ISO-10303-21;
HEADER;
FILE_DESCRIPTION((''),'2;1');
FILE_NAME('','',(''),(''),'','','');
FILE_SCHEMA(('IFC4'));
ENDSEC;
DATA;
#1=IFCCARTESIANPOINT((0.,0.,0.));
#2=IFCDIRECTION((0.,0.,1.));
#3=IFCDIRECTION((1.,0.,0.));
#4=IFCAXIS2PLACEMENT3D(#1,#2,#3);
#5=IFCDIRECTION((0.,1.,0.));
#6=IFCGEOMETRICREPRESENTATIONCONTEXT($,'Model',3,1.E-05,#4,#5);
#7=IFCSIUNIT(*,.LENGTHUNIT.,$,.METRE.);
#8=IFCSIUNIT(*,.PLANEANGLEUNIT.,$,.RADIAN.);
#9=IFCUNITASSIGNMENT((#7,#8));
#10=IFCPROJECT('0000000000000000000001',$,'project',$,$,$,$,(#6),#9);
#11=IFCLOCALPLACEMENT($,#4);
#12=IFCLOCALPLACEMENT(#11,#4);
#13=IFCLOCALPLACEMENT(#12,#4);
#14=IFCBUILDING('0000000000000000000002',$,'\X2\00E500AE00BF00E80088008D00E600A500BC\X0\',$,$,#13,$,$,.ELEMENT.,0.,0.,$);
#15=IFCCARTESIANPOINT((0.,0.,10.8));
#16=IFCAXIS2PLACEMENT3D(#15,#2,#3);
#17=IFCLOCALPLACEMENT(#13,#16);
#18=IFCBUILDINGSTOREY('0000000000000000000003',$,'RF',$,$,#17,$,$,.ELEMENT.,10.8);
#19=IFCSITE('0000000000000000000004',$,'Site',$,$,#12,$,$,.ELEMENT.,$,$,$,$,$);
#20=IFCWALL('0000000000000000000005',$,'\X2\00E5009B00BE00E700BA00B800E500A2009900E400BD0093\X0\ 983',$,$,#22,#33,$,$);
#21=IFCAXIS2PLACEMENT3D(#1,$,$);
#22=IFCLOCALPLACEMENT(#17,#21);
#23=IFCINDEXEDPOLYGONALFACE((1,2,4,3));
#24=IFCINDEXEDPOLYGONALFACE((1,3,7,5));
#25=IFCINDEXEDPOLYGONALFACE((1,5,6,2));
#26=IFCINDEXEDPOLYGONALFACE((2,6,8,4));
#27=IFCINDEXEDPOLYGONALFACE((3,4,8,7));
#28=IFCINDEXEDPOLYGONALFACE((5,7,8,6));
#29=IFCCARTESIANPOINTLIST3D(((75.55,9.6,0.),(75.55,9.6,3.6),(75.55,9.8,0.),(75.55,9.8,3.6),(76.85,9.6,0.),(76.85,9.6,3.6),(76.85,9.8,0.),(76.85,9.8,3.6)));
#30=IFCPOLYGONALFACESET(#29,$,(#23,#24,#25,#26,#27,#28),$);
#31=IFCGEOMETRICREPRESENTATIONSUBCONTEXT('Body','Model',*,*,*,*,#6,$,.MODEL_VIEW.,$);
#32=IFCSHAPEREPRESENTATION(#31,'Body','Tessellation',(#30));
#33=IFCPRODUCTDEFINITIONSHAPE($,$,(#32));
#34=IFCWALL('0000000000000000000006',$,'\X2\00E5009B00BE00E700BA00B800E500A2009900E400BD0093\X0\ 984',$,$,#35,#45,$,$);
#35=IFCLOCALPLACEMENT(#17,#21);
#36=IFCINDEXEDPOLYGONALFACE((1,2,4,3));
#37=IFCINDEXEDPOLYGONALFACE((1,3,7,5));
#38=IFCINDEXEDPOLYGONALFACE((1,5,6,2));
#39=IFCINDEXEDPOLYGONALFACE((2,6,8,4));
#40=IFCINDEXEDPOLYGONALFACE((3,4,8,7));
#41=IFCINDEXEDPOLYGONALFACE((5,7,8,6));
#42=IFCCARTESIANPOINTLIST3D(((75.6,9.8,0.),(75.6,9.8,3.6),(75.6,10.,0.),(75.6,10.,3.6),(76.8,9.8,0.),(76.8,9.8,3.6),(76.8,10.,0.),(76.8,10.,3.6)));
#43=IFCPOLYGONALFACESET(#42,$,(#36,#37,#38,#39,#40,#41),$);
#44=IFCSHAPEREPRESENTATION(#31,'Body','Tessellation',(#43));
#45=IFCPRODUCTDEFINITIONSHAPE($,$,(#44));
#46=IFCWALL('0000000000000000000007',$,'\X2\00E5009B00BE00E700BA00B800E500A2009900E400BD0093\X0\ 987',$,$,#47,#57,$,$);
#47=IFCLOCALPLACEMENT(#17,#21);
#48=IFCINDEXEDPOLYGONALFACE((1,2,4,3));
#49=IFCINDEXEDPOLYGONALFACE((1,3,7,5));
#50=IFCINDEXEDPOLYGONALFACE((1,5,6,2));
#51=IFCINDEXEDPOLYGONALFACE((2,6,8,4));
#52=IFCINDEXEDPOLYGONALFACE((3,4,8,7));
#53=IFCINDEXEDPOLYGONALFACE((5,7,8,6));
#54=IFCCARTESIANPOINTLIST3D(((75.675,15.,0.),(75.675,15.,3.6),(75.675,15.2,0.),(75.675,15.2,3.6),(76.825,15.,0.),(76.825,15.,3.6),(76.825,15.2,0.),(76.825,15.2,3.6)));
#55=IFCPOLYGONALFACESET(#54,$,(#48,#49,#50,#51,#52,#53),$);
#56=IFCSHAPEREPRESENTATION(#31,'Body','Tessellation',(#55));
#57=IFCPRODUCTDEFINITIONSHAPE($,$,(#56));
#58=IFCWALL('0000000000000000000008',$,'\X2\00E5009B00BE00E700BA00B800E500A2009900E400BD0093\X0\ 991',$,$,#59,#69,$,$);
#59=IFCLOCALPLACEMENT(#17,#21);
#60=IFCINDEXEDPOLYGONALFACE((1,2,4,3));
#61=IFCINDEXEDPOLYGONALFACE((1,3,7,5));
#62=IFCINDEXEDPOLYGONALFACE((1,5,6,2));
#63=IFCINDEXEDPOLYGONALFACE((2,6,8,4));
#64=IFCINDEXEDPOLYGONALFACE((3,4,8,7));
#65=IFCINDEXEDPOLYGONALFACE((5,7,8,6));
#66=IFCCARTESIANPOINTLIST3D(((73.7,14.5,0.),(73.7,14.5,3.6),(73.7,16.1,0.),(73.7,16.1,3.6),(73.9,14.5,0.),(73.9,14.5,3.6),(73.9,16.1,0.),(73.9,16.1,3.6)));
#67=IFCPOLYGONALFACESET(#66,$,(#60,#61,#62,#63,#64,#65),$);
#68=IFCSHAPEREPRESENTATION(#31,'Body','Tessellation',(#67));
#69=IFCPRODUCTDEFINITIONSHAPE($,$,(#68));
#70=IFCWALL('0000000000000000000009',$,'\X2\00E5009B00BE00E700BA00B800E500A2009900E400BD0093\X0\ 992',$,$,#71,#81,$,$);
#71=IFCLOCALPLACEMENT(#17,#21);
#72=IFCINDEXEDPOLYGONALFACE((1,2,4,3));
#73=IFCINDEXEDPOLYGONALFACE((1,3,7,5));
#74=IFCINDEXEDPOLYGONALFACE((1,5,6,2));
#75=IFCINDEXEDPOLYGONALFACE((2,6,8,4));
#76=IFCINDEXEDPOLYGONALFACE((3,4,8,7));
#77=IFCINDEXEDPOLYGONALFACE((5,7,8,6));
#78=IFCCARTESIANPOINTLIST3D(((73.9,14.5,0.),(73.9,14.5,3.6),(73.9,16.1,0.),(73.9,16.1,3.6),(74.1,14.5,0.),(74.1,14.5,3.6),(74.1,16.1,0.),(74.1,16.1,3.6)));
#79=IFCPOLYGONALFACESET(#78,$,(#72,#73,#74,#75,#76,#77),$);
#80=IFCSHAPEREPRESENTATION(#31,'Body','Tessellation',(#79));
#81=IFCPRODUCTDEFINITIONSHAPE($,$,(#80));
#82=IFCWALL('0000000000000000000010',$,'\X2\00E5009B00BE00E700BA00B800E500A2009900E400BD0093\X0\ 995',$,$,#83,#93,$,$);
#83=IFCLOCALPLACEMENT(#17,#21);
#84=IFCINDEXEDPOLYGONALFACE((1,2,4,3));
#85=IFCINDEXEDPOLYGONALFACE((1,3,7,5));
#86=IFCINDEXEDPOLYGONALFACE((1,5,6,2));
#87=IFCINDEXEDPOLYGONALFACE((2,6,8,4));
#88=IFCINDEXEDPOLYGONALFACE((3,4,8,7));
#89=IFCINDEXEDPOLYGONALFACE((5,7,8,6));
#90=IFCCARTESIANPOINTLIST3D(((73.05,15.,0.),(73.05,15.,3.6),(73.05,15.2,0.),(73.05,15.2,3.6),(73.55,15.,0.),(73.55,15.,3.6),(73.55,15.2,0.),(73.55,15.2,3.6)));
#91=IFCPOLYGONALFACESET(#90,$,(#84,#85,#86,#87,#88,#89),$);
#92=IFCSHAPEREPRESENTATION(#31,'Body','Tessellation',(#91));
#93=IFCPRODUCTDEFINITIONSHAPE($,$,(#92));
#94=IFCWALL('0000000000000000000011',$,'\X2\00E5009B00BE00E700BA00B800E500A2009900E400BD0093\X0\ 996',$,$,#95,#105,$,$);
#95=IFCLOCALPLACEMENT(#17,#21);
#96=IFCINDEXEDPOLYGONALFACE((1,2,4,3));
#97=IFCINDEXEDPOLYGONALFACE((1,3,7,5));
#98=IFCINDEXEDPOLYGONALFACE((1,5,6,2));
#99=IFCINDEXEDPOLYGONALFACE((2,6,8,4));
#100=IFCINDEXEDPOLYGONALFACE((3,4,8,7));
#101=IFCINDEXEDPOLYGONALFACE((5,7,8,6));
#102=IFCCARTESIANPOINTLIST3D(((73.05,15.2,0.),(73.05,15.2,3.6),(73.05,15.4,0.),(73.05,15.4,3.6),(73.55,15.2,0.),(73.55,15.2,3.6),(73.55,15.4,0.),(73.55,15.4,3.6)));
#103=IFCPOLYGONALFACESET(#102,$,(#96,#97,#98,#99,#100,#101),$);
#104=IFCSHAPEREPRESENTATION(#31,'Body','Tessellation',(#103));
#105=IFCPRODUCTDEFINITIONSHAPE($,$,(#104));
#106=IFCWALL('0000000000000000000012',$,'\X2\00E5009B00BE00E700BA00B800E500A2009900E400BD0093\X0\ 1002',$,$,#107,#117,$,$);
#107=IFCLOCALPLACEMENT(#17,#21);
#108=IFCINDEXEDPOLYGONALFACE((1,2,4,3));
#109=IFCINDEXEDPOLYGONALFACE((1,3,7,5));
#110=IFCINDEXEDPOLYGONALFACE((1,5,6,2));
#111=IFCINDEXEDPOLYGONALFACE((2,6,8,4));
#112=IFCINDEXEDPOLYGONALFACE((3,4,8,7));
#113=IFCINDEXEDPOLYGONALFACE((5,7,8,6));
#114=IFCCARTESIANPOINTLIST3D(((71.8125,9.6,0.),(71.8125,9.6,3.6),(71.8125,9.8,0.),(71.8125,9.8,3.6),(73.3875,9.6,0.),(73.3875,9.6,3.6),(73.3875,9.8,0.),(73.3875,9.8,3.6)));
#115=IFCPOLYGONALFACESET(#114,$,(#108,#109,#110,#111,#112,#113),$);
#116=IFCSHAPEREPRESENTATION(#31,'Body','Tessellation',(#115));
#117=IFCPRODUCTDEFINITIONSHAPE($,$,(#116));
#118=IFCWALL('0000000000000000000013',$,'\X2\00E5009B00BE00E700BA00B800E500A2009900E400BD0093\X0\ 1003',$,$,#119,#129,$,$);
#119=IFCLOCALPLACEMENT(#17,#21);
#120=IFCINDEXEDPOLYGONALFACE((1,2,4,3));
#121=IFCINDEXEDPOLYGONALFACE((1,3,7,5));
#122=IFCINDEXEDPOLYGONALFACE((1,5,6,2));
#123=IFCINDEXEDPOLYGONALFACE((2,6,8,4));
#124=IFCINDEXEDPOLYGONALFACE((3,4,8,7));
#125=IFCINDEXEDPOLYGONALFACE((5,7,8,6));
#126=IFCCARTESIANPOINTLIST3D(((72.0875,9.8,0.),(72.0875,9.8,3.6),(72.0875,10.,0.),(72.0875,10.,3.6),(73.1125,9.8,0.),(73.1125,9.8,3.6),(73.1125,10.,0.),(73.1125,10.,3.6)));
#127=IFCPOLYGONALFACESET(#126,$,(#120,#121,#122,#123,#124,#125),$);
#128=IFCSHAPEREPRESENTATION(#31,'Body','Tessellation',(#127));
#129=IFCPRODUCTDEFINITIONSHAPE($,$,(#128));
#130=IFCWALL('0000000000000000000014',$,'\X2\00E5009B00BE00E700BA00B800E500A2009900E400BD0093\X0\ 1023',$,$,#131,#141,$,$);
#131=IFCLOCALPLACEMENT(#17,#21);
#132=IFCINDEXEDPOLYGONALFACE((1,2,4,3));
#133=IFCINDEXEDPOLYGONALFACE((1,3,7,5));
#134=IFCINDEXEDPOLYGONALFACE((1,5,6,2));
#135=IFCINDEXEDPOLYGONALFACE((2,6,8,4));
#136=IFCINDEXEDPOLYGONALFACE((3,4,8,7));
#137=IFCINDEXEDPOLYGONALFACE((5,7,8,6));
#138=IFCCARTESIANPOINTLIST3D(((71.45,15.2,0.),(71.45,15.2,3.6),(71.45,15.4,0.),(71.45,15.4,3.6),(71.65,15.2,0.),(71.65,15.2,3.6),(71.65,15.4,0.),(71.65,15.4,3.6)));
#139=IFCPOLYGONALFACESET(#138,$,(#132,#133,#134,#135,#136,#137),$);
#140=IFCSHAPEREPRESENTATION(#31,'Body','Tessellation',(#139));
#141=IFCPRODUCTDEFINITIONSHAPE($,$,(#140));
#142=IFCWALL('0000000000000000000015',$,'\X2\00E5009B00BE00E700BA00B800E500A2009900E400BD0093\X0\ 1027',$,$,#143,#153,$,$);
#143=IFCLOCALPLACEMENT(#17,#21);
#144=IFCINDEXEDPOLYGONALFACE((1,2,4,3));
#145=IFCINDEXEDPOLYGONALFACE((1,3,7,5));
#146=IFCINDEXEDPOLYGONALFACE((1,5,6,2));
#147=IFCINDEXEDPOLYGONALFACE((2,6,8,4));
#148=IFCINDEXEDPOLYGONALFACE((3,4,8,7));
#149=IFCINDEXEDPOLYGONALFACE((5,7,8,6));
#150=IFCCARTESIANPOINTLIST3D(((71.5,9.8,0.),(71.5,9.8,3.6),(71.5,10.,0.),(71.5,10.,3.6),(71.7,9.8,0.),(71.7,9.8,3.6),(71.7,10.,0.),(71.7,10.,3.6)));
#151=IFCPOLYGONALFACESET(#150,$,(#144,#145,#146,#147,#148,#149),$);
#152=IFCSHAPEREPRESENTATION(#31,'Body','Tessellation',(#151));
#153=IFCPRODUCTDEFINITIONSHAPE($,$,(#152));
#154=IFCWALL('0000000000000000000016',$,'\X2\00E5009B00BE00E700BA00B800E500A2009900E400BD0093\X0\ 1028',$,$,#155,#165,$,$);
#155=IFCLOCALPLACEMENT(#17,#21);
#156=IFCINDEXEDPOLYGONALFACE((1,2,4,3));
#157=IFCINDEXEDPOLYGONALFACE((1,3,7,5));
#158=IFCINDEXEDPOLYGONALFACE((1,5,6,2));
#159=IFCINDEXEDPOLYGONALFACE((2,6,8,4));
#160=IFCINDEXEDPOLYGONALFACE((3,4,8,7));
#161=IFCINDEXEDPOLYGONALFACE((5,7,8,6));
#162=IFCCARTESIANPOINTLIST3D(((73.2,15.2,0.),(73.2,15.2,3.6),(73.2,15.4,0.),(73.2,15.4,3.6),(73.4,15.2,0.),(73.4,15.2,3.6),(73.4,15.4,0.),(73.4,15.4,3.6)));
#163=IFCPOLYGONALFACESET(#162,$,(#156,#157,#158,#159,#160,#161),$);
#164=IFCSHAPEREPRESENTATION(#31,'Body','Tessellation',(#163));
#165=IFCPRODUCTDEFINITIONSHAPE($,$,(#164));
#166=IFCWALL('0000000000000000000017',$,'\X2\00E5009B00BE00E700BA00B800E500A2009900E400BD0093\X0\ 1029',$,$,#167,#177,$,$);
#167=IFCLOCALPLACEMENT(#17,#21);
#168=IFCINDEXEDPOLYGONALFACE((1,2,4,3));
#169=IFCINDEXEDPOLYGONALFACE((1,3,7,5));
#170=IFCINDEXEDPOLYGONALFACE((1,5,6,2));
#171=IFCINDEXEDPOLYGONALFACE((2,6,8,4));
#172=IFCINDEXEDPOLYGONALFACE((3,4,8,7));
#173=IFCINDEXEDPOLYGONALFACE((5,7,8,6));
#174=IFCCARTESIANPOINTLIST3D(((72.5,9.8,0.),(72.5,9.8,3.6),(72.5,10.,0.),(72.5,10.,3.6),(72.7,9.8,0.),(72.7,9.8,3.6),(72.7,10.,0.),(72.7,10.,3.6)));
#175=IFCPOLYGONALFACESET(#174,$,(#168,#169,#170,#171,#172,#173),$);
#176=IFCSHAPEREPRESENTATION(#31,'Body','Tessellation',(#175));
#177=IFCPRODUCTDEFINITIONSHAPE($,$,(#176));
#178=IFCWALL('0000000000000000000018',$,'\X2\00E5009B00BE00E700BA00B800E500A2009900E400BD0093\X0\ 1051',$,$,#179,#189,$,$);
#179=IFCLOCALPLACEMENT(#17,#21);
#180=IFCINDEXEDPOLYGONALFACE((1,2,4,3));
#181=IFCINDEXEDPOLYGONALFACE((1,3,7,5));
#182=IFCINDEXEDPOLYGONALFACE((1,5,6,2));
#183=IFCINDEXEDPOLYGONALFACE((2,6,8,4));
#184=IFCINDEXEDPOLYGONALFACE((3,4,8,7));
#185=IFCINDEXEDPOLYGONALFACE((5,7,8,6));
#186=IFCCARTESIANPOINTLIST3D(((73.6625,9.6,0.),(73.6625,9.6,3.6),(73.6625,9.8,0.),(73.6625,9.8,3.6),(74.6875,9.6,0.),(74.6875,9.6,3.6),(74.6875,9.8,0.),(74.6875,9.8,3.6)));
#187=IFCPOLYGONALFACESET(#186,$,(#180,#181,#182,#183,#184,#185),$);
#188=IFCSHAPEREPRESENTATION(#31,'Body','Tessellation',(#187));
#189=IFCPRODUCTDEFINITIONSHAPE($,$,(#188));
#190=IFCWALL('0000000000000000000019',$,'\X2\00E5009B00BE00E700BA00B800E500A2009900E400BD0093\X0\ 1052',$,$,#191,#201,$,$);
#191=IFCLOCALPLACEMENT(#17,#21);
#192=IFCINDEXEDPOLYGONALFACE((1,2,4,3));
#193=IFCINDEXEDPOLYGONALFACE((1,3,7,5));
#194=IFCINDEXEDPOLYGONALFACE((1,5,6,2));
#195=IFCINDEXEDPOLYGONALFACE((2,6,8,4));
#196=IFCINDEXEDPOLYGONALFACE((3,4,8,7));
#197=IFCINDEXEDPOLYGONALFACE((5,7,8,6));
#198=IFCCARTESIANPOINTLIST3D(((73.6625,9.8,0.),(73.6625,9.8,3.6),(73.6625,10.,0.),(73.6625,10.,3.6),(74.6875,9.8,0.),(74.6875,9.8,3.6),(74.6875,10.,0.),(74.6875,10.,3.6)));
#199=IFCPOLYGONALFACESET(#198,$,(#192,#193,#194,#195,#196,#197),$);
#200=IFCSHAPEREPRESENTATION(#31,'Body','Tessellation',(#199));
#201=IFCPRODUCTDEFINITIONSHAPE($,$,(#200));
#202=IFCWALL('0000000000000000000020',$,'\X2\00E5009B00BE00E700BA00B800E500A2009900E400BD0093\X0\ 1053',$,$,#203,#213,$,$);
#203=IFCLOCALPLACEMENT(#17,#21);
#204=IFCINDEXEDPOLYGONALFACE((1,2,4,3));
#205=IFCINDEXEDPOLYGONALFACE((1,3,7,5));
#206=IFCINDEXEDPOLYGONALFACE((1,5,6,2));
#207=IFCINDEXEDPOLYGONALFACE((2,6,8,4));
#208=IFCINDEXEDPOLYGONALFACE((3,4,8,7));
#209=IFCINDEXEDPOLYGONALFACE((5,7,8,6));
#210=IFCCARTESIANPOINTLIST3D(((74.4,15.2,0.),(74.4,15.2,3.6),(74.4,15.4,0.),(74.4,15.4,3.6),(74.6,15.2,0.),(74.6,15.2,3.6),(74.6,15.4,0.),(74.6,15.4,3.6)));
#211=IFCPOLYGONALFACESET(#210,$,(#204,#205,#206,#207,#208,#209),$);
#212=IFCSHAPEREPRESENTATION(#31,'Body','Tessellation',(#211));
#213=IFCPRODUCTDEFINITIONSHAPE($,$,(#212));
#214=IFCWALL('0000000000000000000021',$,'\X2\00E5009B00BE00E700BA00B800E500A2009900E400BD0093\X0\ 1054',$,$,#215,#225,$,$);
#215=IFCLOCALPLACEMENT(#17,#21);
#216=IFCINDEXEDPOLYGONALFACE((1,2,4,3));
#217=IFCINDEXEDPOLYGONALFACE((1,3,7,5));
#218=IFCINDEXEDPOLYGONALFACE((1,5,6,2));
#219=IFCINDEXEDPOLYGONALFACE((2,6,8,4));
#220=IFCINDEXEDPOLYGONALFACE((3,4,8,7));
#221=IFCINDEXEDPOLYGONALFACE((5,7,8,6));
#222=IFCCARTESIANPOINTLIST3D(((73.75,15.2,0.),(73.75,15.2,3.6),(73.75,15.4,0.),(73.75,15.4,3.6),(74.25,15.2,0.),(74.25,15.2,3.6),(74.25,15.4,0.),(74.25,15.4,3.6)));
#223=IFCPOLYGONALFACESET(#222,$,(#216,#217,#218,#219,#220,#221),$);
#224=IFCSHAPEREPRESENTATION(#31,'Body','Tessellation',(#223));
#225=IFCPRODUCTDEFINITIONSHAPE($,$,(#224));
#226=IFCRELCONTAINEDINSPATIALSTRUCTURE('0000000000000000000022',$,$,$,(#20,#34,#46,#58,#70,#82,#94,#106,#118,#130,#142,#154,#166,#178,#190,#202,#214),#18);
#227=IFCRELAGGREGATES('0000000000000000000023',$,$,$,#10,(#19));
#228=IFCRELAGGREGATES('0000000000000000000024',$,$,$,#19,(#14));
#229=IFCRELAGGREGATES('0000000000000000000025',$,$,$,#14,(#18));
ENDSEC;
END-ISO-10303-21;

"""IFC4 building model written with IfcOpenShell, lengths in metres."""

from ifc_helpers import new_model, si_unit, direction, frame, frame_2d, origin_with_axes, place, context, subcontext, project, spatial, rectangle, extrude, element, save


model = new_model("IFC4")

# Units and contexts
model_context = context("Model", 3, precision=1e-05, world=origin_with_axes(), true_north=direction((0.0, 1.0, 0.0)))
body_context = subcontext(model_context, "Body", "Model", "MODEL_VIEW")
ifc_project = project(units=[si_unit("LENGTHUNIT", "METRE"), si_unit("PLANEANGLEUNIT", "RADIAN")], contexts=[model_context])

# Site, building, storey
placement = place(None, origin_with_axes())
site_placement = place(placement, origin_with_axes())
site = spatial("IfcSite", under=ifc_project, at=site_placement, Name="Site", CompositionType="ELEMENT")
building_placement = place(site_placement, origin_with_axes())
building = spatial("IfcBuilding", under=site, at=building_placement, Name="å®¿è\u0088\u008dæ¥¼", CompositionType="ELEMENT", ElevationOfRefHeight=0.0, ElevationOfTerrain=0.0)
storey_placement = place(building_placement, frame((0.0, 0.0, 10.8), z_axis=(0.0, 0.0, 1.0), x_axis=(1.0, 0.0, 0.0)))
storey = spatial("IfcBuildingStorey", under=building, at=storey_placement, Name="RF", CompositionType="ELEMENT", Elevation=10.8)

# Walls
wall_1_placement = place(storey_placement, frame((76.2, 9.7, 0.0), z_axis=(0.0, 0.0, 1.0), x_axis=(1.0, 0.0, 0.0)))
element("IfcWall", 1, at=wall_1_placement, inside=storey, Name="å\u009b¾çº¸å¢\u0099ä½\u0093 983", context=body_context, shape_type="SweptSolid", body=[
    extrude(rectangle(XDim=1.3, YDim=0.2, at=frame_2d((0.0, 0.0), x_axis=(1.0, 0.0, 0.0))), frame((0.0, 0.0, 0.0), z_axis=(0.0, 0.0, 1.0)), (0.0, 0.0, 1.0), 3.6),
])
wall_2_placement = place(storey_placement, frame((76.2, 9.9, 0.0), z_axis=(0.0, 0.0, 1.0), x_axis=(1.0, 0.0, 0.0)))
element("IfcWall", 2, at=wall_2_placement, inside=storey, Name="å\u009b¾çº¸å¢\u0099ä½\u0093 984", context=body_context, shape_type="SweptSolid", body=[
    extrude(rectangle(XDim=1.2, YDim=0.2, at=frame_2d((0.0, 0.0), x_axis=(1.0, 0.0, 0.0))), frame((0.0, 0.0, 0.0), z_axis=(0.0, 0.0, 1.0)), (0.0, 0.0, 1.0), 3.6),
])
wall_3_placement = place(storey_placement, frame((76.25, 15.1, 0.0), z_axis=(0.0, 0.0, 1.0), x_axis=(1.0, 0.0, 0.0)))
element("IfcWall", 3, at=wall_3_placement, inside=storey, Name="å\u009b¾çº¸å¢\u0099ä½\u0093 987", context=body_context, shape_type="SweptSolid", body=[
    extrude(rectangle(XDim=1.15, YDim=0.2, at=frame_2d((0.0, 0.0), x_axis=(1.0, 0.0, 0.0))), frame((0.0, 0.0, 0.0), z_axis=(0.0, 0.0, 1.0)), (0.0, 0.0, 1.0), 3.6),
])
for number, where, z_axis, x_axis, name in (
    (4, (73.8, 15.3, 0.0), (0.0, 0.0, 1.0), (0.0, 1.0, 0.0), "å\u009b¾çº¸å¢\u0099ä½\u0093 991"),
    (5, (74.0, 15.3, 0.0), (0.0, 0.0, 1.0), (0.0, 1.0, 0.0), "å\u009b¾çº¸å¢\u0099ä½\u0093 992"),
):
    element("IfcWall", number, at=place(storey_placement, frame(where, z_axis=z_axis, x_axis=x_axis)), inside=storey, Name=name, context=body_context, shape_type="SweptSolid", body=[
        extrude(rectangle(XDim=1.6, YDim=0.2, at=frame_2d((0.0, 0.0), x_axis=(1.0, 0.0, 0.0))), frame((0.0, 0.0, 0.0), z_axis=(0.0, 0.0, 1.0)), (0.0, 0.0, 1.0), 3.6),
    ])
for number, where, z_axis, x_axis, name in (
    (6, (73.3, 15.1, 0.0), (0.0, 0.0, 1.0), (1.0, 0.0, 0.0), "å\u009b¾çº¸å¢\u0099ä½\u0093 995"),
    (7, (73.3, 15.3, 0.0), (0.0, 0.0, 1.0), (1.0, 0.0, 0.0), "å\u009b¾çº¸å¢\u0099ä½\u0093 996"),
):
    element("IfcWall", number, at=place(storey_placement, frame(where, z_axis=z_axis, x_axis=x_axis)), inside=storey, Name=name, context=body_context, shape_type="SweptSolid", body=[
        extrude(rectangle(XDim=0.5, YDim=0.2, at=frame_2d((0.0, 0.0), x_axis=(1.0, 0.0, 0.0))), frame((0.0, 0.0, 0.0), z_axis=(0.0, 0.0, 1.0)), (0.0, 0.0, 1.0), 3.6),
    ])
wall_4_placement = place(storey_placement, frame((72.6, 9.7, 0.0), z_axis=(0.0, 0.0, 1.0), x_axis=(1.0, 0.0, 0.0)))
element("IfcWall", 8, at=wall_4_placement, inside=storey, Name="å\u009b¾çº¸å¢\u0099ä½\u0093 1002", context=body_context, shape_type="SweptSolid", body=[
    extrude(rectangle(XDim=1.575, YDim=0.2, at=frame_2d((0.0, 0.0), x_axis=(1.0, 0.0, 0.0))), frame((0.0, 0.0, 0.0), z_axis=(0.0, 0.0, 1.0)), (0.0, 0.0, 1.0), 3.6),
])
wall_5_placement = place(storey_placement, frame((72.6, 9.9, 0.0), z_axis=(0.0, 0.0, 1.0), x_axis=(1.0, 0.0, 0.0)))
element("IfcWall", 9, at=wall_5_placement, inside=storey, Name="å\u009b¾çº¸å¢\u0099ä½\u0093 1003", context=body_context, shape_type="SweptSolid", body=[
    extrude(rectangle(XDim=1.025, YDim=0.2, at=frame_2d((0.0, 0.0), x_axis=(1.0, 0.0, 0.0))), frame((0.0, 0.0, 0.0), z_axis=(0.0, 0.0, 1.0)), (0.0, 0.0, 1.0), 3.6),
])
for number, where, z_axis, x_axis, name in (
    (10, (71.55, 15.3, 0.0), (0.0, 0.0, 1.0), (0.0, -1.0, 0.0), "å\u009b¾çº¸å¢\u0099ä½\u0093 1023"),
    (11, (71.6, 9.9, 0.0), (0.0, 0.0, 1.0), (0.0, -1.0, 0.0), "å\u009b¾çº¸å¢\u0099ä½\u0093 1027"),
    (12, (73.3, 15.3, 0.0), (0.0, 0.0, 1.0), (0.0, -1.0, 0.0), "å\u009b¾çº¸å¢\u0099ä½\u0093 1028"),
    (13, (72.6, 9.9, 0.0), (0.0, 0.0, 1.0), (0.0, -1.0, 0.0), "å\u009b¾çº¸å¢\u0099ä½\u0093 1029"),
):
    element("IfcWall", number, at=place(storey_placement, frame(where, z_axis=z_axis, x_axis=x_axis)), inside=storey, Name=name, context=body_context, shape_type="SweptSolid", body=[
        extrude(rectangle(XDim=0.2, YDim=0.2, at=frame_2d((0.0, 0.0), x_axis=(1.0, 0.0, 0.0))), frame((0.0, 0.0, 0.0), z_axis=(0.0, 0.0, 1.0)), (0.0, 0.0, 1.0), 3.6),
    ])
for number, where, z_axis, x_axis, name in (
    (14, (74.175, 9.7, 0.0), (0.0, 0.0, 1.0), (1.0, 0.0, 0.0), "å\u009b¾çº¸å¢\u0099ä½\u0093 1051"),
    (15, (74.175, 9.9, 0.0), (0.0, 0.0, 1.0), (1.0, 0.0, 0.0), "å\u009b¾çº¸å¢\u0099ä½\u0093 1052"),
):
    element("IfcWall", number, at=place(storey_placement, frame(where, z_axis=z_axis, x_axis=x_axis)), inside=storey, Name=name, context=body_context, shape_type="SweptSolid", body=[
        extrude(rectangle(XDim=1.025, YDim=0.2, at=frame_2d((0.0, 0.0), x_axis=(1.0, 0.0, 0.0))), frame((0.0, 0.0, 0.0), z_axis=(0.0, 0.0, 1.0)), (0.0, 0.0, 1.0), 3.6),
    ])
wall_6_placement = place(storey_placement, frame((74.5, 15.3, 0.0), z_axis=(0.0, 0.0, 1.0), x_axis=(0.0, -1.0, 0.0)))
element("IfcWall", 16, at=wall_6_placement, inside=storey, Name="å\u009b¾çº¸å¢\u0099ä½\u0093 1053", context=body_context, shape_type="SweptSolid", body=[
    extrude(rectangle(XDim=0.2, YDim=0.2, at=frame_2d((0.0, 0.0), x_axis=(1.0, 0.0, 0.0))), frame((0.0, 0.0, 0.0), z_axis=(0.0, 0.0, 1.0)), (0.0, 0.0, 1.0), 3.6),
])
for number, where, z_axis, x_axis, name in (
    (17, (74.0, 15.3, 0.0), (0.0, 0.0, 1.0), (1.0, 0.0, 0.0), "å\u009b¾çº¸å¢\u0099ä½\u0093 1054"),
):
    element("IfcWall", number, at=place(storey_placement, frame(where, z_axis=z_axis, x_axis=x_axis)), inside=storey, Name=name, context=body_context, shape_type="SweptSolid", body=[
        extrude(rectangle(XDim=0.5, YDim=0.2, at=frame_2d((0.0, 0.0), x_axis=(1.0, 0.0, 0.0))), frame((0.0, 0.0, 0.0), z_axis=(0.0, 0.0, 1.0)), (0.0, 0.0, 1.0), 3.6),
    ])

save(model, "model.ifc")
